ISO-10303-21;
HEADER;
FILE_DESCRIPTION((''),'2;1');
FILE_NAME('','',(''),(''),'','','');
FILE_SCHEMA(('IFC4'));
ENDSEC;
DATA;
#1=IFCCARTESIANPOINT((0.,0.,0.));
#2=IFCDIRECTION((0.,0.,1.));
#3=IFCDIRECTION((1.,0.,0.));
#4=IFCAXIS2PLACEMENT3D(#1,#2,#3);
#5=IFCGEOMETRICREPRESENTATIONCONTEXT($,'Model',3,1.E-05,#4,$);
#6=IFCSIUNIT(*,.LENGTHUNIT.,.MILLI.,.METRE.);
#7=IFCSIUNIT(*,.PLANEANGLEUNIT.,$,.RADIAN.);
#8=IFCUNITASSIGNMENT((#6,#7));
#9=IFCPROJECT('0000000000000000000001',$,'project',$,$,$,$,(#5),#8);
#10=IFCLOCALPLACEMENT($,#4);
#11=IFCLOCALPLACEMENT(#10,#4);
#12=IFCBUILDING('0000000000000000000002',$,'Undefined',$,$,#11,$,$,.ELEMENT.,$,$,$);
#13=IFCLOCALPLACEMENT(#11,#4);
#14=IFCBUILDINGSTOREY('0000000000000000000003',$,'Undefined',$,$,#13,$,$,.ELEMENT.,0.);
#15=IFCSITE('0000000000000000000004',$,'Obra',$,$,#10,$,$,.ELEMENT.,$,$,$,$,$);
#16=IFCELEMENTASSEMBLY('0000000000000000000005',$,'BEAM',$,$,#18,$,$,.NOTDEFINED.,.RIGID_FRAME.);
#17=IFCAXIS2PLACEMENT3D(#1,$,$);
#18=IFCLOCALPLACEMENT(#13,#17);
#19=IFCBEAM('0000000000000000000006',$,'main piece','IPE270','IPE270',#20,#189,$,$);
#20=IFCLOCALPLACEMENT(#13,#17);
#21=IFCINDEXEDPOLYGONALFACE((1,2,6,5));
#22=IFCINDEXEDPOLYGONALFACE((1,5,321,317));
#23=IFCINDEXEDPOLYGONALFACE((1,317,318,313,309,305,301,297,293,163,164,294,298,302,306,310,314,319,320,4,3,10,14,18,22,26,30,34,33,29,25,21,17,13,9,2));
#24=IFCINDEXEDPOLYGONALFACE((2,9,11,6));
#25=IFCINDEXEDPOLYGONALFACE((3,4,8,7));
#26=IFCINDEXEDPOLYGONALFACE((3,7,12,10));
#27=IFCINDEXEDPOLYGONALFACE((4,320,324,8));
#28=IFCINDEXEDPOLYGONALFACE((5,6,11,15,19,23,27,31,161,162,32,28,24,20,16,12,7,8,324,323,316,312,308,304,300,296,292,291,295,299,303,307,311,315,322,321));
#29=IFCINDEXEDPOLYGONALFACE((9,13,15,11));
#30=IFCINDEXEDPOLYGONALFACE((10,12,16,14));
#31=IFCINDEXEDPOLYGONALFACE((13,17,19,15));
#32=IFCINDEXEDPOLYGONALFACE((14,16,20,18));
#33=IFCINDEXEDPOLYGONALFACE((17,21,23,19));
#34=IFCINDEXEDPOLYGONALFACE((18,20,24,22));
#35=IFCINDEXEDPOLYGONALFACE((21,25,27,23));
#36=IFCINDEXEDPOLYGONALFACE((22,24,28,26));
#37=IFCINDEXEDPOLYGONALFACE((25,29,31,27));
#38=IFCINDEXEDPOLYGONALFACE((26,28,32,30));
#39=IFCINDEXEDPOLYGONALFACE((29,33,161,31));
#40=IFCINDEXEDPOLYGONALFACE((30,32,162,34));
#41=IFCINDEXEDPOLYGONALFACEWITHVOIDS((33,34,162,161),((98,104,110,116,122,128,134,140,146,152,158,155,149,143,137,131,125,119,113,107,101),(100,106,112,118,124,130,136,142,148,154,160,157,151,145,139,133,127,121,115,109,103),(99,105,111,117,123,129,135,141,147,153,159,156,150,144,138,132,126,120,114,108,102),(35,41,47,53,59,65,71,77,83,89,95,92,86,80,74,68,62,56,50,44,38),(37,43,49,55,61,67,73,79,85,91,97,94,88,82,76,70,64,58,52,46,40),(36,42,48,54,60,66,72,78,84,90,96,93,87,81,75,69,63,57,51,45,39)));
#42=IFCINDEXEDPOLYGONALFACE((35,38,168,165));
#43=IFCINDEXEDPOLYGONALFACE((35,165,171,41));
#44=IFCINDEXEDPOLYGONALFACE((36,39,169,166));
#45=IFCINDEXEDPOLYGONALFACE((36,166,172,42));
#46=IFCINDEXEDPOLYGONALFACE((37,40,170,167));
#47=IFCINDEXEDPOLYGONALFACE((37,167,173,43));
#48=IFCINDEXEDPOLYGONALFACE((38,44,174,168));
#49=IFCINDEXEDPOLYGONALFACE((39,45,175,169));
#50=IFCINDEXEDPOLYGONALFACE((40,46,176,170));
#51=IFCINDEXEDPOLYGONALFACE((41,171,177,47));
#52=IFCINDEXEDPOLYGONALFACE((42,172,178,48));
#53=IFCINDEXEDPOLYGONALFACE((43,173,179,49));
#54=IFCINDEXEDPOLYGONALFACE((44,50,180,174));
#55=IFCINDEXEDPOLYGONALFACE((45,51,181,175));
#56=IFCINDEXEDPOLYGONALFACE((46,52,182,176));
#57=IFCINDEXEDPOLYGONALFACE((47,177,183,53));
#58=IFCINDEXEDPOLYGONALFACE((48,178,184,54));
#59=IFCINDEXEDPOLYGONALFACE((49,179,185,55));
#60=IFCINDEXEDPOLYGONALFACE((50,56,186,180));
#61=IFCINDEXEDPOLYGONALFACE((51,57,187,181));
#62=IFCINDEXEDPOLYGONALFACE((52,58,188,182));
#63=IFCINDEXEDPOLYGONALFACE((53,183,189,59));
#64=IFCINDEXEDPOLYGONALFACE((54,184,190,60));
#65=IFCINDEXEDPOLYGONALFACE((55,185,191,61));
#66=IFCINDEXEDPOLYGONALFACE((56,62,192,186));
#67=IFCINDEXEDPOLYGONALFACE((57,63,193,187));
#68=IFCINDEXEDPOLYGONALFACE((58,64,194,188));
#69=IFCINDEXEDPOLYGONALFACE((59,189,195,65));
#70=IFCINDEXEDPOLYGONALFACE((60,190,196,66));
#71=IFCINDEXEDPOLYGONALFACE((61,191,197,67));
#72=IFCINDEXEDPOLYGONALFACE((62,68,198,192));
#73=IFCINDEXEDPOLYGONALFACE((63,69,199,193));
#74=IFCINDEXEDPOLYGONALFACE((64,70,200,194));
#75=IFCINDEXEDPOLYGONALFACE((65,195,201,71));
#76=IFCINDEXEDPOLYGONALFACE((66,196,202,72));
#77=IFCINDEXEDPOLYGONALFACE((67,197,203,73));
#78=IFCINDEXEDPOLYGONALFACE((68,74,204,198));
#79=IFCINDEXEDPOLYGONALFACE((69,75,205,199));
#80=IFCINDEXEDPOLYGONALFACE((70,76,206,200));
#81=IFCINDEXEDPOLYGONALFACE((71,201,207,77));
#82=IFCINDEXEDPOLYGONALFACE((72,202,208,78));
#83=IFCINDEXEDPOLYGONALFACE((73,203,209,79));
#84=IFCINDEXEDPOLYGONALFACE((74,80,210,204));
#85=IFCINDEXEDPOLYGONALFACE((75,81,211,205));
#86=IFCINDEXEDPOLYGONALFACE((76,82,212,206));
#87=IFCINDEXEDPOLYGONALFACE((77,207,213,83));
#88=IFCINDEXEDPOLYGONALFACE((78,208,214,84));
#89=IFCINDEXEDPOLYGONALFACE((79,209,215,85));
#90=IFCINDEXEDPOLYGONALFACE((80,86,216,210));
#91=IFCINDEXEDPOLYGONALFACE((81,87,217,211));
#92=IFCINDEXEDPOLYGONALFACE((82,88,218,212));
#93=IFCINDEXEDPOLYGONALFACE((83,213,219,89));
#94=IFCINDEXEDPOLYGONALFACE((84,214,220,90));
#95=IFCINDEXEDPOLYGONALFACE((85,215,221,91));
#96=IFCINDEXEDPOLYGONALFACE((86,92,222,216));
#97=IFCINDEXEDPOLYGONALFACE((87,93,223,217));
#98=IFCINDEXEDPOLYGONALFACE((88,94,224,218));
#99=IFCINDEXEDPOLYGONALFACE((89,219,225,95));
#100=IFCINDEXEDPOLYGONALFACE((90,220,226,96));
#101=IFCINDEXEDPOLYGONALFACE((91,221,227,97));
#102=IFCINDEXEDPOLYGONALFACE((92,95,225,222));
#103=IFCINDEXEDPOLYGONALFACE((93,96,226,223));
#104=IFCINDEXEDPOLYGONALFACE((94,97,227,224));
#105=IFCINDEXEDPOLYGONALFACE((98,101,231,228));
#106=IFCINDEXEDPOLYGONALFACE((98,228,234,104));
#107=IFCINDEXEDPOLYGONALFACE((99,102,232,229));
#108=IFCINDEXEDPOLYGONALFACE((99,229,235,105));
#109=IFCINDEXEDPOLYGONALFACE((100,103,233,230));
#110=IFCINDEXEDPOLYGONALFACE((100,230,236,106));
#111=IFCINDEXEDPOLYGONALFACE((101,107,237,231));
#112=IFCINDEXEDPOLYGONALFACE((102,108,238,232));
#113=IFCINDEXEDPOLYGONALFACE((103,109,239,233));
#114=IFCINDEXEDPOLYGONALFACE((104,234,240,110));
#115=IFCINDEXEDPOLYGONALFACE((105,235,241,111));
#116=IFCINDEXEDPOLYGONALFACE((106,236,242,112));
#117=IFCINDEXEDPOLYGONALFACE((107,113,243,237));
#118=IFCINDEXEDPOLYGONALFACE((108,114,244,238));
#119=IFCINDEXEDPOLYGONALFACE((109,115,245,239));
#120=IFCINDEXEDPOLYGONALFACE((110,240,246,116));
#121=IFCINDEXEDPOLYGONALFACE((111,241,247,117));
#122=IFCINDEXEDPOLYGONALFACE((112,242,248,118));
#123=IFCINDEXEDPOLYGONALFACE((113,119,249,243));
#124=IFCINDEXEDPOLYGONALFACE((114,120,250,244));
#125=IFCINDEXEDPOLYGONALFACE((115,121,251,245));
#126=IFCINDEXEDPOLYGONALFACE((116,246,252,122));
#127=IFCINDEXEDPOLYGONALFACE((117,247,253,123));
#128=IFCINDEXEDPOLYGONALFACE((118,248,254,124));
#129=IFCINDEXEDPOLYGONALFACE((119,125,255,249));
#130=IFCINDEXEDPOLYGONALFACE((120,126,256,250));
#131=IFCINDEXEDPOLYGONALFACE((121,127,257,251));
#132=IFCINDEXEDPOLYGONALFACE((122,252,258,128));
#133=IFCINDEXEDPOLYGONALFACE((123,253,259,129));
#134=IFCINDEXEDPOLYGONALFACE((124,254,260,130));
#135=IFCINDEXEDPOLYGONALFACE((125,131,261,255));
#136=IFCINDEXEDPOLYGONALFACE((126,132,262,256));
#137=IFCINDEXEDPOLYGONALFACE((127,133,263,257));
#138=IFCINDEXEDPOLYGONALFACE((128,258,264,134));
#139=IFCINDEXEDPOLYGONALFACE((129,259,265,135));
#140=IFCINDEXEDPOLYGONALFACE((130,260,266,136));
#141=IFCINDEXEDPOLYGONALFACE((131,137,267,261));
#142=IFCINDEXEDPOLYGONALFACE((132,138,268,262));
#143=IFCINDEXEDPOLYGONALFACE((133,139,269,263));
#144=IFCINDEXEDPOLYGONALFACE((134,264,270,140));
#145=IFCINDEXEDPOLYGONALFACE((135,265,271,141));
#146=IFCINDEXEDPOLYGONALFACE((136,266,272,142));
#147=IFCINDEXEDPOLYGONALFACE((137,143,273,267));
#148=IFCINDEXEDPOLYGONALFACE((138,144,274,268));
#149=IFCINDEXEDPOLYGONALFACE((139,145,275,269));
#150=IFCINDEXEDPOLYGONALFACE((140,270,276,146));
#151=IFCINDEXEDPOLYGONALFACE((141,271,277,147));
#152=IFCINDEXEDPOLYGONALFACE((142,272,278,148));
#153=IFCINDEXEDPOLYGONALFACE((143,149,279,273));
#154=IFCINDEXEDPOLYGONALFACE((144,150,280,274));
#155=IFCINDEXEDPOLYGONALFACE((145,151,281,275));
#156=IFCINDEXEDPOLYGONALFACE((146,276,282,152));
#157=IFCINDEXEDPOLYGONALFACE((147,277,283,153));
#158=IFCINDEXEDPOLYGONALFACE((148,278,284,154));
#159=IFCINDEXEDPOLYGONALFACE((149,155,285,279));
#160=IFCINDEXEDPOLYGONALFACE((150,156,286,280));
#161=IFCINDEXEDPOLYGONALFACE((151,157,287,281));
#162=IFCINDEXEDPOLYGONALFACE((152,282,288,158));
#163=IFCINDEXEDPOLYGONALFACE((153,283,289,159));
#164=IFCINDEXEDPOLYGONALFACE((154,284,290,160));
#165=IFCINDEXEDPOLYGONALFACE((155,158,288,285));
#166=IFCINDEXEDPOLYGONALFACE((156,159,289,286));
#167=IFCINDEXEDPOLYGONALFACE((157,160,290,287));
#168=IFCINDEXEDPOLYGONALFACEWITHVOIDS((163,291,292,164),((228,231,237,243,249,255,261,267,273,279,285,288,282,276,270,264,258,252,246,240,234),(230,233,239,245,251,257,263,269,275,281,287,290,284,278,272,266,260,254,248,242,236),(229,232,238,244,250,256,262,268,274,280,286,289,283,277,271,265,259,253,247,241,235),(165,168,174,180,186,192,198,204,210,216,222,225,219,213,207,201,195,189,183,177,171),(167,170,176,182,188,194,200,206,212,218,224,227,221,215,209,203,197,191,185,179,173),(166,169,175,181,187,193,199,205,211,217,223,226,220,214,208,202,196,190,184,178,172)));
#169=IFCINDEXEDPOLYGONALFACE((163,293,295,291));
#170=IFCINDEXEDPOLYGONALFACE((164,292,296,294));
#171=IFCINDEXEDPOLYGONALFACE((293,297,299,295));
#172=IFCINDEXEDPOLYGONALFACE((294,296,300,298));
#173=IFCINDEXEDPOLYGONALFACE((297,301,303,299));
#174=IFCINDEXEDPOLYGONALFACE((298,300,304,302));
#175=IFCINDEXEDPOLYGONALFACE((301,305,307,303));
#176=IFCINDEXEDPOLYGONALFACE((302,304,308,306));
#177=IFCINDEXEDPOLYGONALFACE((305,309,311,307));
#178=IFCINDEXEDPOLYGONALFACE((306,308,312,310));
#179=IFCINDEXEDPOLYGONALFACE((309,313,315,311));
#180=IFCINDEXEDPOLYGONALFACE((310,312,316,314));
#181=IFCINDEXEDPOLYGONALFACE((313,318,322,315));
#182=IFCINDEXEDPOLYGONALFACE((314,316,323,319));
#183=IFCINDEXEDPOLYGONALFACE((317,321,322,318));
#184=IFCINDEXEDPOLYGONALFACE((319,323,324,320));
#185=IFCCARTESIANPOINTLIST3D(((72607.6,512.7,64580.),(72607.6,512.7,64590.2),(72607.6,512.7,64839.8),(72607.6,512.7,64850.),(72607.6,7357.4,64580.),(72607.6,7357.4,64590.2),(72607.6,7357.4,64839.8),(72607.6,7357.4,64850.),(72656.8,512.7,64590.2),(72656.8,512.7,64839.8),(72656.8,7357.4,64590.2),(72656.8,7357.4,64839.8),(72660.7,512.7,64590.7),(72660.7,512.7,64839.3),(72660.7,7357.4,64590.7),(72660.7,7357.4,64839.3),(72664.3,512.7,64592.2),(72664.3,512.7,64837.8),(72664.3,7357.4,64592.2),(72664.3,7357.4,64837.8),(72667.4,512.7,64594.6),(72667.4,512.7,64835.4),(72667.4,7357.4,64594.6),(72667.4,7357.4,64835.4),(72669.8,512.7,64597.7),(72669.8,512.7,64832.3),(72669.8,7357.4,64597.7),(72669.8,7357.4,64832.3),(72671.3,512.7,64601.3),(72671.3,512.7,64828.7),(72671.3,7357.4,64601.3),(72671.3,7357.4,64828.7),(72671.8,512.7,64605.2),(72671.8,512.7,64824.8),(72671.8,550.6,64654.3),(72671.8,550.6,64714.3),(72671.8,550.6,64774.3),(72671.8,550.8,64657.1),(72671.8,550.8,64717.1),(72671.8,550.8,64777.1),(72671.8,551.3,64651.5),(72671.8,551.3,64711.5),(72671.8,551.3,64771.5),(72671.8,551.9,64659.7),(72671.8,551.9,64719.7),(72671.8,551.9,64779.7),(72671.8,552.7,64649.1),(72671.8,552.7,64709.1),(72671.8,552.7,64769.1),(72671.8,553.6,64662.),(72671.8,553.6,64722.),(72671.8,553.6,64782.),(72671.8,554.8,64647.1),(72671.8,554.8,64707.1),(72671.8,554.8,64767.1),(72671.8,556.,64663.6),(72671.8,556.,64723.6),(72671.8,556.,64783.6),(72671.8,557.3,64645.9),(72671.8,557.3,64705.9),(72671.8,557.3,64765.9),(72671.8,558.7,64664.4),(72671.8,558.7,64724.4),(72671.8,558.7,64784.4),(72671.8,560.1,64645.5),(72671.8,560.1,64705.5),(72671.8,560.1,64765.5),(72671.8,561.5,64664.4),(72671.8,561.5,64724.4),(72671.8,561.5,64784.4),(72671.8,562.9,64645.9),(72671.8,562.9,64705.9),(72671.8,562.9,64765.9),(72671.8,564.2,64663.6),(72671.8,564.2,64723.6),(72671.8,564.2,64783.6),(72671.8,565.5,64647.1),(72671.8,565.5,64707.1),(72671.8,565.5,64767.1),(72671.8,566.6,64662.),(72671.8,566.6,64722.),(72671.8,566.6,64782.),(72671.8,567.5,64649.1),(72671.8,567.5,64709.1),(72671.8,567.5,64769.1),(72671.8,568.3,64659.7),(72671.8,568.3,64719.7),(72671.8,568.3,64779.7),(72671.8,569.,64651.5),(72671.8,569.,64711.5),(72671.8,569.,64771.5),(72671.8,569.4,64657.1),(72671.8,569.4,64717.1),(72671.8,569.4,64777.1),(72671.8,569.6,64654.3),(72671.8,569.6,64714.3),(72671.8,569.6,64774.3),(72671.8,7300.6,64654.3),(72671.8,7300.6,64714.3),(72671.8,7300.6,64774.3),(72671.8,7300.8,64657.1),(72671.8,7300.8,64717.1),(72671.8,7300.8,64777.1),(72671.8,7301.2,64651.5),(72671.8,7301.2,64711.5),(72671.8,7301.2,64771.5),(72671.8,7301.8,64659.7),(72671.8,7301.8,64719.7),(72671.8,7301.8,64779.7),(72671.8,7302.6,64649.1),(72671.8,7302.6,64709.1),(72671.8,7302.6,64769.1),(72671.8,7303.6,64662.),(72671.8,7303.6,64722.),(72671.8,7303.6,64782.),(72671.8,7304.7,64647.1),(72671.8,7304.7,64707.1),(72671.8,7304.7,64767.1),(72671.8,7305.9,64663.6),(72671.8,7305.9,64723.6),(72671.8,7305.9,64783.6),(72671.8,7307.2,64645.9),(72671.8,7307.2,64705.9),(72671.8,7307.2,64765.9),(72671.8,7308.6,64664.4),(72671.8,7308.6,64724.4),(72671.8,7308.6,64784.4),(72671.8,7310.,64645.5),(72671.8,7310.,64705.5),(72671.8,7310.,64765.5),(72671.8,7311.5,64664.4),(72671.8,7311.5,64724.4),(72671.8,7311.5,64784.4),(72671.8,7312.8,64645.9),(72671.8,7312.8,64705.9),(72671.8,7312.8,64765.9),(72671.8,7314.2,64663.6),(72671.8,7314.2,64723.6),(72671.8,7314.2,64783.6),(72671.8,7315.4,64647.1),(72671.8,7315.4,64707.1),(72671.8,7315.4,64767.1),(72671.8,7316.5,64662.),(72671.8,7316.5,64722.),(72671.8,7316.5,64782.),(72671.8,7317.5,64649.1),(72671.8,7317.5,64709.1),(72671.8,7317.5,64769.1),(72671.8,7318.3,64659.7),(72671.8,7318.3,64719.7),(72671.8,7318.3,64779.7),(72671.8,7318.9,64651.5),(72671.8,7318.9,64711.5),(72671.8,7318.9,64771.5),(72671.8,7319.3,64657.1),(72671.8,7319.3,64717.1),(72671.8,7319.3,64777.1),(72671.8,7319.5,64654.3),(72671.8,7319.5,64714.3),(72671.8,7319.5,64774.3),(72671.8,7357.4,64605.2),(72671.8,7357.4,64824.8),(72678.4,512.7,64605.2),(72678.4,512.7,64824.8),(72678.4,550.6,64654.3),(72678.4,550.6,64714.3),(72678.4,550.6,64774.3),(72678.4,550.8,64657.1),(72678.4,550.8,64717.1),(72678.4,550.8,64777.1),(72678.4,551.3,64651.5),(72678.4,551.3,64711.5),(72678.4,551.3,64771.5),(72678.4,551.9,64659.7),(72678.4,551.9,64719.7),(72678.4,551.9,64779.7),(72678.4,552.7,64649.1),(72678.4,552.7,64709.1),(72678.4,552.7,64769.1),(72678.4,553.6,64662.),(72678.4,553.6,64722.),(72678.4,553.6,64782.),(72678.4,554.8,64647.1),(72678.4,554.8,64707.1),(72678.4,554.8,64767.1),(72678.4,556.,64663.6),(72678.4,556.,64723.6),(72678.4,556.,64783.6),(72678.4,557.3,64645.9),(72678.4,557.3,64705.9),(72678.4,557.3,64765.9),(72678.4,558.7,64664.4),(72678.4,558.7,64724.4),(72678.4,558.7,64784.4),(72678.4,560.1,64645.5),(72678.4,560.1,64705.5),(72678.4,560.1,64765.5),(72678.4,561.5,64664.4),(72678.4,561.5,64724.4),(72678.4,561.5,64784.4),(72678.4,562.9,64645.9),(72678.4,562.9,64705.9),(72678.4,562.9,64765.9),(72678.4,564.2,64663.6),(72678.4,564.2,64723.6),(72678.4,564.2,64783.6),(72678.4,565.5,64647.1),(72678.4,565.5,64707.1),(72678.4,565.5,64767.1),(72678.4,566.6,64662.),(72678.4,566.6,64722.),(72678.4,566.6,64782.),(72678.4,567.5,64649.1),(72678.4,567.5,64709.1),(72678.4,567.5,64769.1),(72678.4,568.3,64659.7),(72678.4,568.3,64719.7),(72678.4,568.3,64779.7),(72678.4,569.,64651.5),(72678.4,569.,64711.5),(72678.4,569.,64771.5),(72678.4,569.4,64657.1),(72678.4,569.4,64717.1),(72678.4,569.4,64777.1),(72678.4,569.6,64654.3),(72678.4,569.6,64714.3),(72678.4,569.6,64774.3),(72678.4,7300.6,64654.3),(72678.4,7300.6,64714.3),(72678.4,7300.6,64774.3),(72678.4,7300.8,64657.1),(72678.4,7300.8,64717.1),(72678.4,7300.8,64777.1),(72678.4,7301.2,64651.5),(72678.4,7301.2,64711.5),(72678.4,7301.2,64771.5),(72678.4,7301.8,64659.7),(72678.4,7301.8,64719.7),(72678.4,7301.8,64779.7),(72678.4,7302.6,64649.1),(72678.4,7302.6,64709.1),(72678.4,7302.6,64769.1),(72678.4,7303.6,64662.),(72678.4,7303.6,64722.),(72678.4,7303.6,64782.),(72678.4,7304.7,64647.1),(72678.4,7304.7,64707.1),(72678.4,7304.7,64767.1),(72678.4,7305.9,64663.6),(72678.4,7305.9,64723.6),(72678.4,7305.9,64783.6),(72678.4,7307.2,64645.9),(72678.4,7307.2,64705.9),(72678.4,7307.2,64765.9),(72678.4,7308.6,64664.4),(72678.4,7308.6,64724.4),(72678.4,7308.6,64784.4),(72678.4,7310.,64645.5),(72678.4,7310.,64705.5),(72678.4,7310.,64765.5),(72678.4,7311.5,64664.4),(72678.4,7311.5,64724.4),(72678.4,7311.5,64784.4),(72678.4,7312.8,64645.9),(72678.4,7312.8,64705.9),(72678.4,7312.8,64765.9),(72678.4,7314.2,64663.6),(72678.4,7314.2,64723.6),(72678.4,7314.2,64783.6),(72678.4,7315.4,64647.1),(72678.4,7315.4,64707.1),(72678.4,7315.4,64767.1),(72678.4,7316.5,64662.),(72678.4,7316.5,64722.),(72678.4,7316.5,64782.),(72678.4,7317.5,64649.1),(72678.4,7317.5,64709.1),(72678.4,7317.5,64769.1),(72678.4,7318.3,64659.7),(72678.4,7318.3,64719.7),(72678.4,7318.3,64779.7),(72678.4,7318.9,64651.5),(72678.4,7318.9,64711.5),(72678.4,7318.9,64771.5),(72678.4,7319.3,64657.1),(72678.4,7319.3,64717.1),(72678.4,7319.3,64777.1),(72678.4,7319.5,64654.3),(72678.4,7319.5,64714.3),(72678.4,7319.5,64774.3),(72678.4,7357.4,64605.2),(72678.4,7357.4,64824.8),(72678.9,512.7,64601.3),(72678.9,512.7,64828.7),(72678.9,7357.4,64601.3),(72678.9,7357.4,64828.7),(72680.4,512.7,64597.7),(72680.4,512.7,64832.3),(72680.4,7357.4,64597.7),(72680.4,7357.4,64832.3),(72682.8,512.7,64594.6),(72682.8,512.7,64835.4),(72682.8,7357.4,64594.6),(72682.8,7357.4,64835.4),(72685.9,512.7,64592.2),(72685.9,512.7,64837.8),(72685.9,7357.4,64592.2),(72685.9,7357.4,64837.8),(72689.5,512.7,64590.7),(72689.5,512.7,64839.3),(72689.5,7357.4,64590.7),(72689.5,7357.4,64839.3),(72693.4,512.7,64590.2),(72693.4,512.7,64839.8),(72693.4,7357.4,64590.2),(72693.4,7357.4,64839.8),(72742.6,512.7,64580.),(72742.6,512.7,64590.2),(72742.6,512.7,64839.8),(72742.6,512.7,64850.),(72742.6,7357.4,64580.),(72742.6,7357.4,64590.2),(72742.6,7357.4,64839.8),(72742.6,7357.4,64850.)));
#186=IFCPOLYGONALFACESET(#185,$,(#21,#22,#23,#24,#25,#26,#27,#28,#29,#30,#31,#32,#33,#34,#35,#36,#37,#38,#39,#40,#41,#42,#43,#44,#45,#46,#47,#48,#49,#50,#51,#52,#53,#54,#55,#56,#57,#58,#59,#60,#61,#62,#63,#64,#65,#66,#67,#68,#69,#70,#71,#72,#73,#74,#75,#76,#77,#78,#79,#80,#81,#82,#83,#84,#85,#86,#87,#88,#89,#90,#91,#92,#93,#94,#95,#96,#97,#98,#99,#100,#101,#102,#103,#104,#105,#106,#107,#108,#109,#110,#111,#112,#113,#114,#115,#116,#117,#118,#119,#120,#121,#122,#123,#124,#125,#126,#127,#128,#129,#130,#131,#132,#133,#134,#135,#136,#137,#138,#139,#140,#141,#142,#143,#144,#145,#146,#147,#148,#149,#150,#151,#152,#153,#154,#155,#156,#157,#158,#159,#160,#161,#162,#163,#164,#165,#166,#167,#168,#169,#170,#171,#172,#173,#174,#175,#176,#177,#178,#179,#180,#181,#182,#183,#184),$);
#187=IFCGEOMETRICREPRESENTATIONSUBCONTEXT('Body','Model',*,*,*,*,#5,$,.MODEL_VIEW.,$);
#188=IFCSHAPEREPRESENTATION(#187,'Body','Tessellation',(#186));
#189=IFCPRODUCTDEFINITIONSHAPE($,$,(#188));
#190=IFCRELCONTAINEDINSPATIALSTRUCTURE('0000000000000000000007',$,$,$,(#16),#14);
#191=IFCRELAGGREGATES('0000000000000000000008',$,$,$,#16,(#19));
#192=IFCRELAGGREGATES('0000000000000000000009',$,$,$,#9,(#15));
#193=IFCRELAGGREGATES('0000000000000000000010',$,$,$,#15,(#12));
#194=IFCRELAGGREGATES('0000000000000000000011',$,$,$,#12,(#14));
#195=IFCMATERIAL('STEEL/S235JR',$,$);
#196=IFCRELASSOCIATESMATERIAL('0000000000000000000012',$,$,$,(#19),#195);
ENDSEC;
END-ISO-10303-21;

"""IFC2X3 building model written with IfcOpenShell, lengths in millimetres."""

from ifc_helpers import new_model, si_unit, frame, origin_with_axes, origin_2d_with_axis, place, context, subcontext, project, spatial, circle, i_section, extrude, clip, halfspace, source, transform, mapped, material, element, aggregate, save


model = new_model("IFC2X3")

# Units and contexts
model_context = context("Model", 3, precision=1e-05, world=origin_with_axes())
body_context = subcontext(model_context, "Body", "Model", "MODEL_VIEW")
ifc_project = project(units=[si_unit("LENGTHUNIT", "METRE", prefix="MILLI"), si_unit("PLANEANGLEUNIT", "RADIAN")], contexts=[model_context])

# Site, building, storey
site_placement = place(None, origin_with_axes())
site = spatial("IfcSite", under=ifc_project, at=site_placement, Name="Obra", CompositionType="ELEMENT")
building_placement = place(site_placement, origin_with_axes())
building = spatial("IfcBuilding", under=site, at=building_placement, Name="Undefined", CompositionType="ELEMENT")
storey_placement = place(building_placement, origin_with_axes())
storey = spatial("IfcBuildingStorey", under=building, at=storey_placement, Name="Undefined", CompositionType="ELEMENT", Elevation=0.0)

# Element assembly, beam, openings
ifc_material_1 = material(Name="STEEL/S235JR")
assembly_1_placement = place(storey_placement, origin_with_axes())
assembly_1 = element("IfcElementAssembly", 1, at=assembly_1_placement, inside=storey, Name="BEAM", AssemblyPlace="NOTDEFINED", PredefinedType="RIGID_FRAME")
beam_1_placement = place(assembly_1_placement, frame((72675.1, 512.7, 64715.0), z_axis=(0.0, 0.0, 1.0), x_axis=(0.0, 1.0, 0.0)))
beam_1 = element("IfcBeam", 2, at=beam_1_placement, material=ifc_material_1, Name="main piece", Description="IPE270", ObjectType="IPE270", context=body_context, shape_type="Clipping", body=[
    clip(clip(extrude(i_section(OverallWidth=135.0, OverallDepth=270.0, WebThickness=6.6, FlangeThickness=10.2, FilletRadius=15.0, at=origin_2d_with_axis()), frame((6844.7, 0.0, 0.0), z_axis=(-1.0, 0.0, 0.0), x_axis=(0.0, -1.0, 0.0)), (0.0, 0.0, 1.0), 6844.7), halfspace(frame((6846.8, -60.0, -120.0), z_axis=(1.0, 0.0, 0.0), x_axis=(0.0, 0.0, 1.0)), False)), halfspace(frame((-2.2, 60.0, -120.0), z_axis=(-1.0, -0.000021, 0.0), x_axis=(0.0, 0.0, 1.0)), False)),
])
shared_shape_1 = source(origin_with_axes(), body_context, "Body", "SweptSolid", [
    extrude(circle(Radius=9.5, at=origin_2d_with_axis()), frame((0.0, -3.4, 0.0), z_axis=(0.0, 1.0, 0.0), x_axis=(1.0, 0.0, 0.0)), (0.0, 0.0, 1.0), 6.8),
])
opening_1_placement = place(assembly_1_placement, frame((72675.1, 7360.0, 64835.0), z_axis=(-0.000019, -1.0, 0.0), x_axis=(0.0, 0.0, -1.0)))
element("IfcOpeningElement", 3, at=opening_1_placement, cuts=beam_1, ObjectType="Opening", context=body_context, shape_type="MappedRepresentation", body=[
    mapped(shared_shape_1, transform((60.0, 0.0, 50.0))),
    mapped(shared_shape_1, transform((120.0, 0.0, 50.0))),
    mapped(shared_shape_1, transform((180.0, 0.0, 50.0))),
])
shared_shape_2 = source(origin_with_axes(), body_context, "Body", "SweptSolid", [
    extrude(circle(Radius=9.5, at=origin_2d_with_axis()), frame((0.0, -3.4, 0.0), z_axis=(0.0, 1.0, 0.0), x_axis=(1.0, 0.0, 0.0)), (0.0, 0.0, 1.0), 6.8),
])
opening_2_placement = place(assembly_1_placement, frame((72675.1, 510.1, 64835.0), z_axis=(-0.000002, 1.0, 0.0), x_axis=(0.0, 0.0, -1.0)))
element("IfcOpeningElement", 4, at=opening_2_placement, cuts=beam_1, ObjectType="Opening", context=body_context, shape_type="MappedRepresentation", body=[
    mapped(shared_shape_2, transform((60.0, 0.0, 50.0))),
    mapped(shared_shape_2, transform((120.0, 0.0, 50.0))),
    mapped(shared_shape_2, transform((180.0, 0.0, 50.0))),
])

aggregate(assembly_1, [beam_1])

save(model, "model.ifc")
